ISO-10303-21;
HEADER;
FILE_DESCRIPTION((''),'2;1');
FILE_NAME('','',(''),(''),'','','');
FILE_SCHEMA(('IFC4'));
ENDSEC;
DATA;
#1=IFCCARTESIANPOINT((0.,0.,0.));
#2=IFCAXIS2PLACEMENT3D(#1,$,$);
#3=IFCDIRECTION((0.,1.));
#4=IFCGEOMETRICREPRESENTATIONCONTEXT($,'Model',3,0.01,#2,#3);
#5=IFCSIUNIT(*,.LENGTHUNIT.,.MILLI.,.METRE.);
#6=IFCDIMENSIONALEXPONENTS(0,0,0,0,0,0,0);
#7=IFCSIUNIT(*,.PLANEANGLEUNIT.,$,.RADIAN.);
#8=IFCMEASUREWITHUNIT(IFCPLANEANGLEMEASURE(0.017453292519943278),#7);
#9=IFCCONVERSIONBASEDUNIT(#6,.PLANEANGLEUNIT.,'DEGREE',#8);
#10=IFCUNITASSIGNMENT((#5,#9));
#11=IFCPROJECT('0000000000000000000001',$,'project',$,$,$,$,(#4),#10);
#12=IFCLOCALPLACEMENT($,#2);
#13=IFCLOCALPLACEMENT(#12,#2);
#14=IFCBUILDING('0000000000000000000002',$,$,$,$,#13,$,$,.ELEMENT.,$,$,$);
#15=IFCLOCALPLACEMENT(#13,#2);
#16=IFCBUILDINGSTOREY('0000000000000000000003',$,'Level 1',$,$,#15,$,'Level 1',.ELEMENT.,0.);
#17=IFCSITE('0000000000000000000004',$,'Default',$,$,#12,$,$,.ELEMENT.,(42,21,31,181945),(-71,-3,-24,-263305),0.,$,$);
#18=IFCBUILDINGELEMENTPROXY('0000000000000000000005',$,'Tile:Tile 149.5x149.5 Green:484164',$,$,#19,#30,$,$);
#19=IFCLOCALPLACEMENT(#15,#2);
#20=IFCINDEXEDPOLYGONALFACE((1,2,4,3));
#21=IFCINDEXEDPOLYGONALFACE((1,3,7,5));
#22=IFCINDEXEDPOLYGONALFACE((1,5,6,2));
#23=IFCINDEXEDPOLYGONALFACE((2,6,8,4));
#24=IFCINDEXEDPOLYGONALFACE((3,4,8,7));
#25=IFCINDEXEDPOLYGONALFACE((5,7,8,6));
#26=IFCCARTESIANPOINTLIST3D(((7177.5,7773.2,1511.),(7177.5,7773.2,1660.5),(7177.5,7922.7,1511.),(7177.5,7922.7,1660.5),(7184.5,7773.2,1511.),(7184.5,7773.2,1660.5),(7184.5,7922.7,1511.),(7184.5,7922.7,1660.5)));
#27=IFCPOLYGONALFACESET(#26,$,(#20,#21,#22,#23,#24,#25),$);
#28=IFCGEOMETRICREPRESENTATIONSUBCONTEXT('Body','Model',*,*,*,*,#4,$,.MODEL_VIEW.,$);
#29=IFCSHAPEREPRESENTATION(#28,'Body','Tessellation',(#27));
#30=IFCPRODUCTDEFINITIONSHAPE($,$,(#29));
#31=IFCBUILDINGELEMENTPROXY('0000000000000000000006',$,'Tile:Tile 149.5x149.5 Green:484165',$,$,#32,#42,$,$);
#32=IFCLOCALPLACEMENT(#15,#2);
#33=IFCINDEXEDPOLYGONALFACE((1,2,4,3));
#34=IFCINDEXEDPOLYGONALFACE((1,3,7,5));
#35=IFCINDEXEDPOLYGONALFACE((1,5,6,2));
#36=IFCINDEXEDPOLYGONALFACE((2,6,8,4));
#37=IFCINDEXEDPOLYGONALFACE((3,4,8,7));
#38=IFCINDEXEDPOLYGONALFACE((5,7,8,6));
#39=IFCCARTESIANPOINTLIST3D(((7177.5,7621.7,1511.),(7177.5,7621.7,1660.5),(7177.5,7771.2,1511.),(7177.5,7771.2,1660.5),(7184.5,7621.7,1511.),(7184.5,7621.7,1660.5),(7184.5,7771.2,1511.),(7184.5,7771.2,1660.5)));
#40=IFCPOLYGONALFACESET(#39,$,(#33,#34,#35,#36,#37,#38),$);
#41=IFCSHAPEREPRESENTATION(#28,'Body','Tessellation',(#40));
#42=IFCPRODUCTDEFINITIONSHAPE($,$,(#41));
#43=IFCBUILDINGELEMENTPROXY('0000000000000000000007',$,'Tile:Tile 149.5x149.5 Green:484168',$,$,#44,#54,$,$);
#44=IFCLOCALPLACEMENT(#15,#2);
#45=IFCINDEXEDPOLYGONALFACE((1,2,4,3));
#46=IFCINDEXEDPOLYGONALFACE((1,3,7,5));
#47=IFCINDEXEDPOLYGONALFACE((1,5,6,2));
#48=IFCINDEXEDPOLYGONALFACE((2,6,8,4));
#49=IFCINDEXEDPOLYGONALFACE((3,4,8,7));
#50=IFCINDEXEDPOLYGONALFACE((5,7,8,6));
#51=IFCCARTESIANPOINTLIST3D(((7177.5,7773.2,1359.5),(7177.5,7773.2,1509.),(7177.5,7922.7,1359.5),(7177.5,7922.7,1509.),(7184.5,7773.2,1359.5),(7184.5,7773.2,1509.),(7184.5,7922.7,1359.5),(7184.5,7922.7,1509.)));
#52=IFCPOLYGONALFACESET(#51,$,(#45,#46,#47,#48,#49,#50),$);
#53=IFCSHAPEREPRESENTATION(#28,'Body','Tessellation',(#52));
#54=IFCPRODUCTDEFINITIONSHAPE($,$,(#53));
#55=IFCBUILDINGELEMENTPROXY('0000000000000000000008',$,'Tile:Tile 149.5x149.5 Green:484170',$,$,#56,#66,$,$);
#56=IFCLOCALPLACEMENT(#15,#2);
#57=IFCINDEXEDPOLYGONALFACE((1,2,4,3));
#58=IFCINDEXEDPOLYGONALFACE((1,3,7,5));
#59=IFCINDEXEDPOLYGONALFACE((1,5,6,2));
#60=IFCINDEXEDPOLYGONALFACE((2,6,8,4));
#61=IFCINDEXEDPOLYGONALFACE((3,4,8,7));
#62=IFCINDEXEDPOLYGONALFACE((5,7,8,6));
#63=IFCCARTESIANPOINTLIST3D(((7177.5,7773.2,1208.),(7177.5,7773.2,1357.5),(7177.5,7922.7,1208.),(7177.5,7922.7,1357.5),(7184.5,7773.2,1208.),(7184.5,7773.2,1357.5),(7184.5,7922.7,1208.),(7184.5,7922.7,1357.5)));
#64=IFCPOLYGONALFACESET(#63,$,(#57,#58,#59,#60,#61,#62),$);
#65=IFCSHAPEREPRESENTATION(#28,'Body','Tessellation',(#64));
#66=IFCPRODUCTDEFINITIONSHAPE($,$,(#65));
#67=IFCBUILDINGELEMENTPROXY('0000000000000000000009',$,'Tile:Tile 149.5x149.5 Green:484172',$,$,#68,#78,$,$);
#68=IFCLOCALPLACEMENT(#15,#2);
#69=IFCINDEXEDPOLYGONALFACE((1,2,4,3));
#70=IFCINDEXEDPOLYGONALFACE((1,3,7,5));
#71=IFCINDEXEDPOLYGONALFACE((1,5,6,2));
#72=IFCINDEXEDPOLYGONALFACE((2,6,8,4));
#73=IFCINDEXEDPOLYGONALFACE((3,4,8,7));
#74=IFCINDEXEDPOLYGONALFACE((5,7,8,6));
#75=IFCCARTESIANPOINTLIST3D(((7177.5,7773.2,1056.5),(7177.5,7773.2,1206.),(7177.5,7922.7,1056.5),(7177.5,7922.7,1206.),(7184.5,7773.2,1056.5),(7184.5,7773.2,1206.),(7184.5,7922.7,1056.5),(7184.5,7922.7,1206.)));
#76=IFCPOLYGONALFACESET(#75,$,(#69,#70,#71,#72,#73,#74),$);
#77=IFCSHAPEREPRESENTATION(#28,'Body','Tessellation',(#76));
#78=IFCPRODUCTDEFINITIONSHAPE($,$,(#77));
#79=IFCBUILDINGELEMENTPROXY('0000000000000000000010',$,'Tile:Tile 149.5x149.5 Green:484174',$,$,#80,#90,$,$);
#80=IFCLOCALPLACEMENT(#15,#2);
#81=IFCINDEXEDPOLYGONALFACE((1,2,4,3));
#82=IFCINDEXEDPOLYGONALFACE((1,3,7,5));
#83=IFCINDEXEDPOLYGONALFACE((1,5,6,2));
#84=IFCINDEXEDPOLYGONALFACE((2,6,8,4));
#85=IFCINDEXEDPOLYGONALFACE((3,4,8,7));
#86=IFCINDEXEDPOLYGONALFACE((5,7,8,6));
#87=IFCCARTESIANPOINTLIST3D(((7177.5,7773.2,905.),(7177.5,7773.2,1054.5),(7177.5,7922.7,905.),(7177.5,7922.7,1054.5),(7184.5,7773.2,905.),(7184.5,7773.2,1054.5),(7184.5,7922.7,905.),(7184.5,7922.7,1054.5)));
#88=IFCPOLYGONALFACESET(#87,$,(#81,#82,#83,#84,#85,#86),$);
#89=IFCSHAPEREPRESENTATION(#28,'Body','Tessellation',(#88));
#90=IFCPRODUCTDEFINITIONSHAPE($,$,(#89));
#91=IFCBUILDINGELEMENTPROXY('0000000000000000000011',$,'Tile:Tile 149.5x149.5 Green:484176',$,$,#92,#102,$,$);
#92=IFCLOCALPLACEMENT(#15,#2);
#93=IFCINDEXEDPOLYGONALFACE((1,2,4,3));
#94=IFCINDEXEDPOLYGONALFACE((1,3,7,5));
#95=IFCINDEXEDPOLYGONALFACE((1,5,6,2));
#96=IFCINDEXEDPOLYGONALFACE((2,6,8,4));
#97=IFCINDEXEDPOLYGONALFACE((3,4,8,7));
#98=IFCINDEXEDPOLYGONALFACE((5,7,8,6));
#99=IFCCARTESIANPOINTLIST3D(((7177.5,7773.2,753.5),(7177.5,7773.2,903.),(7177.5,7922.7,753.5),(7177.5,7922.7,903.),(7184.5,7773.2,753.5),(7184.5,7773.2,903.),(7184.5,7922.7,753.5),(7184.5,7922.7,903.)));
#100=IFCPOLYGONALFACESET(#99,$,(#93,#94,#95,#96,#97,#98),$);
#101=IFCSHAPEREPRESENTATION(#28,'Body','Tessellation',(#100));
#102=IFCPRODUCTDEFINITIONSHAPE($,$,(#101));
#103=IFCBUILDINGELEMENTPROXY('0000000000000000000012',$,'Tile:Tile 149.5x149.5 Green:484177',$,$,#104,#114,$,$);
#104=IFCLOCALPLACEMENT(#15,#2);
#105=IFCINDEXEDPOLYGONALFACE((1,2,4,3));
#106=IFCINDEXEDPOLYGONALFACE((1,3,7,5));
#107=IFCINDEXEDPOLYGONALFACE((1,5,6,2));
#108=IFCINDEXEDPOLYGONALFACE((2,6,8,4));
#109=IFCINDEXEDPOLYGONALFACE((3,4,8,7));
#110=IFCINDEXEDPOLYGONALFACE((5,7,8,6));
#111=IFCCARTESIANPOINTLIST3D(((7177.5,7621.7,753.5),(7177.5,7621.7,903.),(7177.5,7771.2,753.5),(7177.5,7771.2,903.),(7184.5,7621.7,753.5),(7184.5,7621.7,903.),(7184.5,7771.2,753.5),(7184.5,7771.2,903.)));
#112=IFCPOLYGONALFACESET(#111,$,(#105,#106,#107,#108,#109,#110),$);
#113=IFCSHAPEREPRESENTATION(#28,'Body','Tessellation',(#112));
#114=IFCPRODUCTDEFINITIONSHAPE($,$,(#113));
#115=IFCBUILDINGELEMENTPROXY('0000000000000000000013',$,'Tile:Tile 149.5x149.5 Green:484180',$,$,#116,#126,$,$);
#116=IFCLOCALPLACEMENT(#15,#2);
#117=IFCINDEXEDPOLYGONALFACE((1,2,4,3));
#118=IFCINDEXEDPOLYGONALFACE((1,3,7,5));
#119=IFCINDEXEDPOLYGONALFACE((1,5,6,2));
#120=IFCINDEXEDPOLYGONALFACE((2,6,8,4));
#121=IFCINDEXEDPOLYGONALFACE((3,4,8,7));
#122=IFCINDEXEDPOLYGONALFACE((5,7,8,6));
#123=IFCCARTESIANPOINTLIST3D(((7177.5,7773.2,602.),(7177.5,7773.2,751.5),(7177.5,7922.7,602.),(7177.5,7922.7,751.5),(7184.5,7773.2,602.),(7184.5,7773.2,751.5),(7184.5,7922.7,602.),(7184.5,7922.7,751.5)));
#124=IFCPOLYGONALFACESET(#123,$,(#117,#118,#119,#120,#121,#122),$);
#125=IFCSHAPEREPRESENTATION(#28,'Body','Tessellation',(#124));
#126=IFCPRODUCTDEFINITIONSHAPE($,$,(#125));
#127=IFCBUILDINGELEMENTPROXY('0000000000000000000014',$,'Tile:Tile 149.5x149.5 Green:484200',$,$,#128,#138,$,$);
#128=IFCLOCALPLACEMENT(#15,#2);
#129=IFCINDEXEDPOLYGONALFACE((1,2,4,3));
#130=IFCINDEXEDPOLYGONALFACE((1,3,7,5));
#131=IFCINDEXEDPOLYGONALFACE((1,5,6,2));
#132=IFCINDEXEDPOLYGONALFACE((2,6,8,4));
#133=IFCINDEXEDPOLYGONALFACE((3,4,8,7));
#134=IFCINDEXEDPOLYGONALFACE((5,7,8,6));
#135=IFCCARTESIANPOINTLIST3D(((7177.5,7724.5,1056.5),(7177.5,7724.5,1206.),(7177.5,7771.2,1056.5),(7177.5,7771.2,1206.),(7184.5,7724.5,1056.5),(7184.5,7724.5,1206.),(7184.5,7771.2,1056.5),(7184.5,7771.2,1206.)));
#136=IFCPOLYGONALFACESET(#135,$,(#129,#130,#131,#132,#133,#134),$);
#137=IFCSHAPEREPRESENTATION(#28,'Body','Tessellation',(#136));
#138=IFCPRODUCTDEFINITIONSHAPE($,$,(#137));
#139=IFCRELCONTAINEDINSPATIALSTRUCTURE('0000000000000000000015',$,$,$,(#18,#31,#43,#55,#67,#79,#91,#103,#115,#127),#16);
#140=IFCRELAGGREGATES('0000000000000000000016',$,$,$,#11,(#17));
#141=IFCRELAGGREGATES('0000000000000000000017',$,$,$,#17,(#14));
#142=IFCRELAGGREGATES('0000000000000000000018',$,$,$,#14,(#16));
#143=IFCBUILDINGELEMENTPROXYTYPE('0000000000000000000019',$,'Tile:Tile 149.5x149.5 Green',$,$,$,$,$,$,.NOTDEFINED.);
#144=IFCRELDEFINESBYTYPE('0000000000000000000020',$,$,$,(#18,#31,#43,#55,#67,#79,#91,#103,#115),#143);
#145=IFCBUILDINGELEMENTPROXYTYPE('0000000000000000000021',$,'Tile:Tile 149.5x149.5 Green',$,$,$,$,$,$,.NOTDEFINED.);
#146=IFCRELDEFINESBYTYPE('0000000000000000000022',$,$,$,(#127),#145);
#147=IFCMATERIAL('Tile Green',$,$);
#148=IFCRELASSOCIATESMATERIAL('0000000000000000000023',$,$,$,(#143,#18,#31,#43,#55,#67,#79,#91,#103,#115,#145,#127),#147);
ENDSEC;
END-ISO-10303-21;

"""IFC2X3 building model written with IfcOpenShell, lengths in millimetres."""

from ifc_helpers import new_model, entity, si_unit, converted_unit, direction, frame, origin, origin_2d_with_axis, place, context, subcontext, project, spatial, rectangle, extrude, source, transform, mapped, material, type_object, type_shapes, element, save


model = new_model("IFC2X3")

# Units and contexts
model_context = context("Model", 3, precision=0.01, world=origin(), true_north=direction((0.0, 1.0)))
body_context = subcontext(model_context, "Body", "Model", "MODEL_VIEW")
ifc_project = project(units=[si_unit("LENGTHUNIT", "METRE", prefix="MILLI"), converted_unit("PLANEANGLEUNIT", "DEGREE", entity("IfcPlaneAngleMeasure", 0.017453292519943278), si_unit("PLANEANGLEUNIT", "RADIAN"), dimensions=[0, 0, 0, 0, 0, 0, 0])], contexts=[model_context])

# Site, building, storey
site_placement = place(None, origin())
site = spatial("IfcSite", under=ifc_project, at=site_placement, Name="Default", CompositionType="ELEMENT", RefLatitude=(42, 21, 31, 181945), RefLongitude=(-71, -3, -24, -263305), RefElevation=0.0)
building_placement = place(site_placement, origin())
building = spatial("IfcBuilding", under=site, at=building_placement, CompositionType="ELEMENT")
storey_placement = place(building_placement, origin())
storey = spatial("IfcBuildingStorey", under=building, at=storey_placement, Name="Level 1", LongName="Level 1", CompositionType="ELEMENT", Elevation=0.0)

# Building element proxies
ifc_material_1 = material(Name="Tile Green")
building_element_proxy_type_1 = type_object("IfcBuildingElementProxyType", Name="Tile:Tile 149.5x149.5 Green", PredefinedType="NOTDEFINED", material=ifc_material_1)
shared_shape_1 = source(origin(), body_context, "Body", "SweptSolid", [
    extrude(rectangle(XDim=149.5, YDim=149.5, at=origin_2d_with_axis()), frame((-74.7, -74.8, 0.0), z_axis=(0.0, 0.0, 1.0), x_axis=(0.0, -1.0, 0.0)), (0.0, 0.0, 1.0), 7.0),
])
type_shapes(building_element_proxy_type_1, [shared_shape_1])
for number, where, z_axis, x_axis, name in (
    (1, (7184.5, 7922.7, 1660.5), (-1.0, 0.0, 0.0), (0.0, 0.0, 1.0), "Tile:Tile 149.5x149.5 Green:484164"),
    (2, (7184.5, 7771.2, 1660.5), (-1.0, 0.0, 0.0), (0.0, 0.0, 1.0), "Tile:Tile 149.5x149.5 Green:484165"),
    (3, (7184.5, 7922.7, 1509.0), (-1.0, 0.0, 0.0), (0.0, 0.0, 1.0), "Tile:Tile 149.5x149.5 Green:484168"),
    (4, (7184.5, 7922.7, 1357.5), (-1.0, 0.0, 0.0), (0.0, 0.0, 1.0), "Tile:Tile 149.5x149.5 Green:484170"),
    (5, (7184.5, 7922.7, 1206.0), (-1.0, 0.0, 0.0), (0.0, 0.0, 1.0), "Tile:Tile 149.5x149.5 Green:484172"),
    (6, (7184.5, 7922.7, 1054.5), (-1.0, 0.0, 0.0), (0.0, 0.0, 1.0), "Tile:Tile 149.5x149.5 Green:484174"),
    (7, (7184.5, 7922.7, 903.0), (-1.0, 0.0, 0.0), (0.0, 0.0, 1.0), "Tile:Tile 149.5x149.5 Green:484176"),
    (8, (7184.5, 7771.2, 903.0), (-1.0, 0.0, 0.0), (0.0, 0.0, 1.0), "Tile:Tile 149.5x149.5 Green:484177"),
    (9, (7184.5, 7922.7, 751.5), (-1.0, 0.0, 0.0), (0.0, 0.0, 1.0), "Tile:Tile 149.5x149.5 Green:484180"),
):
    element("IfcBuildingElementProxy", number, at=place(storey_placement, frame(where, z_axis=z_axis, x_axis=x_axis)), inside=storey, type_object=building_element_proxy_type_1, material=ifc_material_1, Name=name, context=body_context, shape_type="MappedRepresentation", body=[
        mapped(shared_shape_1, transform((0.0, 0.0, 0.0), scale=1.0)),
    ])
building_element_proxy_type_2 = type_object("IfcBuildingElementProxyType", Name="Tile:Tile 149.5x149.5 Green", PredefinedType="NOTDEFINED", material=ifc_material_1)
shared_shape_2 = source(origin(), body_context, "Body", "SweptSolid", [
    extrude(rectangle(XDim=46.7, YDim=149.5, at=origin_2d_with_axis()), frame((-23.3, -74.8, 0.0), z_axis=(0.0, 0.0, 1.0), x_axis=(-1.0, 0.0, 0.0)), (0.0, 0.0, 1.0), 7.0),
])
type_shapes(building_element_proxy_type_2, [shared_shape_2])
proxy_placement = place(storey_placement, frame((7184.5, 7771.2, 1056.5), z_axis=(-1.0, 0.0, 0.0), x_axis=(0.0, 1.0, 0.0)))
element("IfcBuildingElementProxy", 10, at=proxy_placement, inside=storey, type_object=building_element_proxy_type_2, material=ifc_material_1, Name="Tile:Tile 149.5x149.5 Green:484200", context=body_context, shape_type="MappedRepresentation", body=[
    mapped(shared_shape_2, transform((0.0, 0.0, 0.0), scale=1.0)),
])

save(model, "model.ifc")
